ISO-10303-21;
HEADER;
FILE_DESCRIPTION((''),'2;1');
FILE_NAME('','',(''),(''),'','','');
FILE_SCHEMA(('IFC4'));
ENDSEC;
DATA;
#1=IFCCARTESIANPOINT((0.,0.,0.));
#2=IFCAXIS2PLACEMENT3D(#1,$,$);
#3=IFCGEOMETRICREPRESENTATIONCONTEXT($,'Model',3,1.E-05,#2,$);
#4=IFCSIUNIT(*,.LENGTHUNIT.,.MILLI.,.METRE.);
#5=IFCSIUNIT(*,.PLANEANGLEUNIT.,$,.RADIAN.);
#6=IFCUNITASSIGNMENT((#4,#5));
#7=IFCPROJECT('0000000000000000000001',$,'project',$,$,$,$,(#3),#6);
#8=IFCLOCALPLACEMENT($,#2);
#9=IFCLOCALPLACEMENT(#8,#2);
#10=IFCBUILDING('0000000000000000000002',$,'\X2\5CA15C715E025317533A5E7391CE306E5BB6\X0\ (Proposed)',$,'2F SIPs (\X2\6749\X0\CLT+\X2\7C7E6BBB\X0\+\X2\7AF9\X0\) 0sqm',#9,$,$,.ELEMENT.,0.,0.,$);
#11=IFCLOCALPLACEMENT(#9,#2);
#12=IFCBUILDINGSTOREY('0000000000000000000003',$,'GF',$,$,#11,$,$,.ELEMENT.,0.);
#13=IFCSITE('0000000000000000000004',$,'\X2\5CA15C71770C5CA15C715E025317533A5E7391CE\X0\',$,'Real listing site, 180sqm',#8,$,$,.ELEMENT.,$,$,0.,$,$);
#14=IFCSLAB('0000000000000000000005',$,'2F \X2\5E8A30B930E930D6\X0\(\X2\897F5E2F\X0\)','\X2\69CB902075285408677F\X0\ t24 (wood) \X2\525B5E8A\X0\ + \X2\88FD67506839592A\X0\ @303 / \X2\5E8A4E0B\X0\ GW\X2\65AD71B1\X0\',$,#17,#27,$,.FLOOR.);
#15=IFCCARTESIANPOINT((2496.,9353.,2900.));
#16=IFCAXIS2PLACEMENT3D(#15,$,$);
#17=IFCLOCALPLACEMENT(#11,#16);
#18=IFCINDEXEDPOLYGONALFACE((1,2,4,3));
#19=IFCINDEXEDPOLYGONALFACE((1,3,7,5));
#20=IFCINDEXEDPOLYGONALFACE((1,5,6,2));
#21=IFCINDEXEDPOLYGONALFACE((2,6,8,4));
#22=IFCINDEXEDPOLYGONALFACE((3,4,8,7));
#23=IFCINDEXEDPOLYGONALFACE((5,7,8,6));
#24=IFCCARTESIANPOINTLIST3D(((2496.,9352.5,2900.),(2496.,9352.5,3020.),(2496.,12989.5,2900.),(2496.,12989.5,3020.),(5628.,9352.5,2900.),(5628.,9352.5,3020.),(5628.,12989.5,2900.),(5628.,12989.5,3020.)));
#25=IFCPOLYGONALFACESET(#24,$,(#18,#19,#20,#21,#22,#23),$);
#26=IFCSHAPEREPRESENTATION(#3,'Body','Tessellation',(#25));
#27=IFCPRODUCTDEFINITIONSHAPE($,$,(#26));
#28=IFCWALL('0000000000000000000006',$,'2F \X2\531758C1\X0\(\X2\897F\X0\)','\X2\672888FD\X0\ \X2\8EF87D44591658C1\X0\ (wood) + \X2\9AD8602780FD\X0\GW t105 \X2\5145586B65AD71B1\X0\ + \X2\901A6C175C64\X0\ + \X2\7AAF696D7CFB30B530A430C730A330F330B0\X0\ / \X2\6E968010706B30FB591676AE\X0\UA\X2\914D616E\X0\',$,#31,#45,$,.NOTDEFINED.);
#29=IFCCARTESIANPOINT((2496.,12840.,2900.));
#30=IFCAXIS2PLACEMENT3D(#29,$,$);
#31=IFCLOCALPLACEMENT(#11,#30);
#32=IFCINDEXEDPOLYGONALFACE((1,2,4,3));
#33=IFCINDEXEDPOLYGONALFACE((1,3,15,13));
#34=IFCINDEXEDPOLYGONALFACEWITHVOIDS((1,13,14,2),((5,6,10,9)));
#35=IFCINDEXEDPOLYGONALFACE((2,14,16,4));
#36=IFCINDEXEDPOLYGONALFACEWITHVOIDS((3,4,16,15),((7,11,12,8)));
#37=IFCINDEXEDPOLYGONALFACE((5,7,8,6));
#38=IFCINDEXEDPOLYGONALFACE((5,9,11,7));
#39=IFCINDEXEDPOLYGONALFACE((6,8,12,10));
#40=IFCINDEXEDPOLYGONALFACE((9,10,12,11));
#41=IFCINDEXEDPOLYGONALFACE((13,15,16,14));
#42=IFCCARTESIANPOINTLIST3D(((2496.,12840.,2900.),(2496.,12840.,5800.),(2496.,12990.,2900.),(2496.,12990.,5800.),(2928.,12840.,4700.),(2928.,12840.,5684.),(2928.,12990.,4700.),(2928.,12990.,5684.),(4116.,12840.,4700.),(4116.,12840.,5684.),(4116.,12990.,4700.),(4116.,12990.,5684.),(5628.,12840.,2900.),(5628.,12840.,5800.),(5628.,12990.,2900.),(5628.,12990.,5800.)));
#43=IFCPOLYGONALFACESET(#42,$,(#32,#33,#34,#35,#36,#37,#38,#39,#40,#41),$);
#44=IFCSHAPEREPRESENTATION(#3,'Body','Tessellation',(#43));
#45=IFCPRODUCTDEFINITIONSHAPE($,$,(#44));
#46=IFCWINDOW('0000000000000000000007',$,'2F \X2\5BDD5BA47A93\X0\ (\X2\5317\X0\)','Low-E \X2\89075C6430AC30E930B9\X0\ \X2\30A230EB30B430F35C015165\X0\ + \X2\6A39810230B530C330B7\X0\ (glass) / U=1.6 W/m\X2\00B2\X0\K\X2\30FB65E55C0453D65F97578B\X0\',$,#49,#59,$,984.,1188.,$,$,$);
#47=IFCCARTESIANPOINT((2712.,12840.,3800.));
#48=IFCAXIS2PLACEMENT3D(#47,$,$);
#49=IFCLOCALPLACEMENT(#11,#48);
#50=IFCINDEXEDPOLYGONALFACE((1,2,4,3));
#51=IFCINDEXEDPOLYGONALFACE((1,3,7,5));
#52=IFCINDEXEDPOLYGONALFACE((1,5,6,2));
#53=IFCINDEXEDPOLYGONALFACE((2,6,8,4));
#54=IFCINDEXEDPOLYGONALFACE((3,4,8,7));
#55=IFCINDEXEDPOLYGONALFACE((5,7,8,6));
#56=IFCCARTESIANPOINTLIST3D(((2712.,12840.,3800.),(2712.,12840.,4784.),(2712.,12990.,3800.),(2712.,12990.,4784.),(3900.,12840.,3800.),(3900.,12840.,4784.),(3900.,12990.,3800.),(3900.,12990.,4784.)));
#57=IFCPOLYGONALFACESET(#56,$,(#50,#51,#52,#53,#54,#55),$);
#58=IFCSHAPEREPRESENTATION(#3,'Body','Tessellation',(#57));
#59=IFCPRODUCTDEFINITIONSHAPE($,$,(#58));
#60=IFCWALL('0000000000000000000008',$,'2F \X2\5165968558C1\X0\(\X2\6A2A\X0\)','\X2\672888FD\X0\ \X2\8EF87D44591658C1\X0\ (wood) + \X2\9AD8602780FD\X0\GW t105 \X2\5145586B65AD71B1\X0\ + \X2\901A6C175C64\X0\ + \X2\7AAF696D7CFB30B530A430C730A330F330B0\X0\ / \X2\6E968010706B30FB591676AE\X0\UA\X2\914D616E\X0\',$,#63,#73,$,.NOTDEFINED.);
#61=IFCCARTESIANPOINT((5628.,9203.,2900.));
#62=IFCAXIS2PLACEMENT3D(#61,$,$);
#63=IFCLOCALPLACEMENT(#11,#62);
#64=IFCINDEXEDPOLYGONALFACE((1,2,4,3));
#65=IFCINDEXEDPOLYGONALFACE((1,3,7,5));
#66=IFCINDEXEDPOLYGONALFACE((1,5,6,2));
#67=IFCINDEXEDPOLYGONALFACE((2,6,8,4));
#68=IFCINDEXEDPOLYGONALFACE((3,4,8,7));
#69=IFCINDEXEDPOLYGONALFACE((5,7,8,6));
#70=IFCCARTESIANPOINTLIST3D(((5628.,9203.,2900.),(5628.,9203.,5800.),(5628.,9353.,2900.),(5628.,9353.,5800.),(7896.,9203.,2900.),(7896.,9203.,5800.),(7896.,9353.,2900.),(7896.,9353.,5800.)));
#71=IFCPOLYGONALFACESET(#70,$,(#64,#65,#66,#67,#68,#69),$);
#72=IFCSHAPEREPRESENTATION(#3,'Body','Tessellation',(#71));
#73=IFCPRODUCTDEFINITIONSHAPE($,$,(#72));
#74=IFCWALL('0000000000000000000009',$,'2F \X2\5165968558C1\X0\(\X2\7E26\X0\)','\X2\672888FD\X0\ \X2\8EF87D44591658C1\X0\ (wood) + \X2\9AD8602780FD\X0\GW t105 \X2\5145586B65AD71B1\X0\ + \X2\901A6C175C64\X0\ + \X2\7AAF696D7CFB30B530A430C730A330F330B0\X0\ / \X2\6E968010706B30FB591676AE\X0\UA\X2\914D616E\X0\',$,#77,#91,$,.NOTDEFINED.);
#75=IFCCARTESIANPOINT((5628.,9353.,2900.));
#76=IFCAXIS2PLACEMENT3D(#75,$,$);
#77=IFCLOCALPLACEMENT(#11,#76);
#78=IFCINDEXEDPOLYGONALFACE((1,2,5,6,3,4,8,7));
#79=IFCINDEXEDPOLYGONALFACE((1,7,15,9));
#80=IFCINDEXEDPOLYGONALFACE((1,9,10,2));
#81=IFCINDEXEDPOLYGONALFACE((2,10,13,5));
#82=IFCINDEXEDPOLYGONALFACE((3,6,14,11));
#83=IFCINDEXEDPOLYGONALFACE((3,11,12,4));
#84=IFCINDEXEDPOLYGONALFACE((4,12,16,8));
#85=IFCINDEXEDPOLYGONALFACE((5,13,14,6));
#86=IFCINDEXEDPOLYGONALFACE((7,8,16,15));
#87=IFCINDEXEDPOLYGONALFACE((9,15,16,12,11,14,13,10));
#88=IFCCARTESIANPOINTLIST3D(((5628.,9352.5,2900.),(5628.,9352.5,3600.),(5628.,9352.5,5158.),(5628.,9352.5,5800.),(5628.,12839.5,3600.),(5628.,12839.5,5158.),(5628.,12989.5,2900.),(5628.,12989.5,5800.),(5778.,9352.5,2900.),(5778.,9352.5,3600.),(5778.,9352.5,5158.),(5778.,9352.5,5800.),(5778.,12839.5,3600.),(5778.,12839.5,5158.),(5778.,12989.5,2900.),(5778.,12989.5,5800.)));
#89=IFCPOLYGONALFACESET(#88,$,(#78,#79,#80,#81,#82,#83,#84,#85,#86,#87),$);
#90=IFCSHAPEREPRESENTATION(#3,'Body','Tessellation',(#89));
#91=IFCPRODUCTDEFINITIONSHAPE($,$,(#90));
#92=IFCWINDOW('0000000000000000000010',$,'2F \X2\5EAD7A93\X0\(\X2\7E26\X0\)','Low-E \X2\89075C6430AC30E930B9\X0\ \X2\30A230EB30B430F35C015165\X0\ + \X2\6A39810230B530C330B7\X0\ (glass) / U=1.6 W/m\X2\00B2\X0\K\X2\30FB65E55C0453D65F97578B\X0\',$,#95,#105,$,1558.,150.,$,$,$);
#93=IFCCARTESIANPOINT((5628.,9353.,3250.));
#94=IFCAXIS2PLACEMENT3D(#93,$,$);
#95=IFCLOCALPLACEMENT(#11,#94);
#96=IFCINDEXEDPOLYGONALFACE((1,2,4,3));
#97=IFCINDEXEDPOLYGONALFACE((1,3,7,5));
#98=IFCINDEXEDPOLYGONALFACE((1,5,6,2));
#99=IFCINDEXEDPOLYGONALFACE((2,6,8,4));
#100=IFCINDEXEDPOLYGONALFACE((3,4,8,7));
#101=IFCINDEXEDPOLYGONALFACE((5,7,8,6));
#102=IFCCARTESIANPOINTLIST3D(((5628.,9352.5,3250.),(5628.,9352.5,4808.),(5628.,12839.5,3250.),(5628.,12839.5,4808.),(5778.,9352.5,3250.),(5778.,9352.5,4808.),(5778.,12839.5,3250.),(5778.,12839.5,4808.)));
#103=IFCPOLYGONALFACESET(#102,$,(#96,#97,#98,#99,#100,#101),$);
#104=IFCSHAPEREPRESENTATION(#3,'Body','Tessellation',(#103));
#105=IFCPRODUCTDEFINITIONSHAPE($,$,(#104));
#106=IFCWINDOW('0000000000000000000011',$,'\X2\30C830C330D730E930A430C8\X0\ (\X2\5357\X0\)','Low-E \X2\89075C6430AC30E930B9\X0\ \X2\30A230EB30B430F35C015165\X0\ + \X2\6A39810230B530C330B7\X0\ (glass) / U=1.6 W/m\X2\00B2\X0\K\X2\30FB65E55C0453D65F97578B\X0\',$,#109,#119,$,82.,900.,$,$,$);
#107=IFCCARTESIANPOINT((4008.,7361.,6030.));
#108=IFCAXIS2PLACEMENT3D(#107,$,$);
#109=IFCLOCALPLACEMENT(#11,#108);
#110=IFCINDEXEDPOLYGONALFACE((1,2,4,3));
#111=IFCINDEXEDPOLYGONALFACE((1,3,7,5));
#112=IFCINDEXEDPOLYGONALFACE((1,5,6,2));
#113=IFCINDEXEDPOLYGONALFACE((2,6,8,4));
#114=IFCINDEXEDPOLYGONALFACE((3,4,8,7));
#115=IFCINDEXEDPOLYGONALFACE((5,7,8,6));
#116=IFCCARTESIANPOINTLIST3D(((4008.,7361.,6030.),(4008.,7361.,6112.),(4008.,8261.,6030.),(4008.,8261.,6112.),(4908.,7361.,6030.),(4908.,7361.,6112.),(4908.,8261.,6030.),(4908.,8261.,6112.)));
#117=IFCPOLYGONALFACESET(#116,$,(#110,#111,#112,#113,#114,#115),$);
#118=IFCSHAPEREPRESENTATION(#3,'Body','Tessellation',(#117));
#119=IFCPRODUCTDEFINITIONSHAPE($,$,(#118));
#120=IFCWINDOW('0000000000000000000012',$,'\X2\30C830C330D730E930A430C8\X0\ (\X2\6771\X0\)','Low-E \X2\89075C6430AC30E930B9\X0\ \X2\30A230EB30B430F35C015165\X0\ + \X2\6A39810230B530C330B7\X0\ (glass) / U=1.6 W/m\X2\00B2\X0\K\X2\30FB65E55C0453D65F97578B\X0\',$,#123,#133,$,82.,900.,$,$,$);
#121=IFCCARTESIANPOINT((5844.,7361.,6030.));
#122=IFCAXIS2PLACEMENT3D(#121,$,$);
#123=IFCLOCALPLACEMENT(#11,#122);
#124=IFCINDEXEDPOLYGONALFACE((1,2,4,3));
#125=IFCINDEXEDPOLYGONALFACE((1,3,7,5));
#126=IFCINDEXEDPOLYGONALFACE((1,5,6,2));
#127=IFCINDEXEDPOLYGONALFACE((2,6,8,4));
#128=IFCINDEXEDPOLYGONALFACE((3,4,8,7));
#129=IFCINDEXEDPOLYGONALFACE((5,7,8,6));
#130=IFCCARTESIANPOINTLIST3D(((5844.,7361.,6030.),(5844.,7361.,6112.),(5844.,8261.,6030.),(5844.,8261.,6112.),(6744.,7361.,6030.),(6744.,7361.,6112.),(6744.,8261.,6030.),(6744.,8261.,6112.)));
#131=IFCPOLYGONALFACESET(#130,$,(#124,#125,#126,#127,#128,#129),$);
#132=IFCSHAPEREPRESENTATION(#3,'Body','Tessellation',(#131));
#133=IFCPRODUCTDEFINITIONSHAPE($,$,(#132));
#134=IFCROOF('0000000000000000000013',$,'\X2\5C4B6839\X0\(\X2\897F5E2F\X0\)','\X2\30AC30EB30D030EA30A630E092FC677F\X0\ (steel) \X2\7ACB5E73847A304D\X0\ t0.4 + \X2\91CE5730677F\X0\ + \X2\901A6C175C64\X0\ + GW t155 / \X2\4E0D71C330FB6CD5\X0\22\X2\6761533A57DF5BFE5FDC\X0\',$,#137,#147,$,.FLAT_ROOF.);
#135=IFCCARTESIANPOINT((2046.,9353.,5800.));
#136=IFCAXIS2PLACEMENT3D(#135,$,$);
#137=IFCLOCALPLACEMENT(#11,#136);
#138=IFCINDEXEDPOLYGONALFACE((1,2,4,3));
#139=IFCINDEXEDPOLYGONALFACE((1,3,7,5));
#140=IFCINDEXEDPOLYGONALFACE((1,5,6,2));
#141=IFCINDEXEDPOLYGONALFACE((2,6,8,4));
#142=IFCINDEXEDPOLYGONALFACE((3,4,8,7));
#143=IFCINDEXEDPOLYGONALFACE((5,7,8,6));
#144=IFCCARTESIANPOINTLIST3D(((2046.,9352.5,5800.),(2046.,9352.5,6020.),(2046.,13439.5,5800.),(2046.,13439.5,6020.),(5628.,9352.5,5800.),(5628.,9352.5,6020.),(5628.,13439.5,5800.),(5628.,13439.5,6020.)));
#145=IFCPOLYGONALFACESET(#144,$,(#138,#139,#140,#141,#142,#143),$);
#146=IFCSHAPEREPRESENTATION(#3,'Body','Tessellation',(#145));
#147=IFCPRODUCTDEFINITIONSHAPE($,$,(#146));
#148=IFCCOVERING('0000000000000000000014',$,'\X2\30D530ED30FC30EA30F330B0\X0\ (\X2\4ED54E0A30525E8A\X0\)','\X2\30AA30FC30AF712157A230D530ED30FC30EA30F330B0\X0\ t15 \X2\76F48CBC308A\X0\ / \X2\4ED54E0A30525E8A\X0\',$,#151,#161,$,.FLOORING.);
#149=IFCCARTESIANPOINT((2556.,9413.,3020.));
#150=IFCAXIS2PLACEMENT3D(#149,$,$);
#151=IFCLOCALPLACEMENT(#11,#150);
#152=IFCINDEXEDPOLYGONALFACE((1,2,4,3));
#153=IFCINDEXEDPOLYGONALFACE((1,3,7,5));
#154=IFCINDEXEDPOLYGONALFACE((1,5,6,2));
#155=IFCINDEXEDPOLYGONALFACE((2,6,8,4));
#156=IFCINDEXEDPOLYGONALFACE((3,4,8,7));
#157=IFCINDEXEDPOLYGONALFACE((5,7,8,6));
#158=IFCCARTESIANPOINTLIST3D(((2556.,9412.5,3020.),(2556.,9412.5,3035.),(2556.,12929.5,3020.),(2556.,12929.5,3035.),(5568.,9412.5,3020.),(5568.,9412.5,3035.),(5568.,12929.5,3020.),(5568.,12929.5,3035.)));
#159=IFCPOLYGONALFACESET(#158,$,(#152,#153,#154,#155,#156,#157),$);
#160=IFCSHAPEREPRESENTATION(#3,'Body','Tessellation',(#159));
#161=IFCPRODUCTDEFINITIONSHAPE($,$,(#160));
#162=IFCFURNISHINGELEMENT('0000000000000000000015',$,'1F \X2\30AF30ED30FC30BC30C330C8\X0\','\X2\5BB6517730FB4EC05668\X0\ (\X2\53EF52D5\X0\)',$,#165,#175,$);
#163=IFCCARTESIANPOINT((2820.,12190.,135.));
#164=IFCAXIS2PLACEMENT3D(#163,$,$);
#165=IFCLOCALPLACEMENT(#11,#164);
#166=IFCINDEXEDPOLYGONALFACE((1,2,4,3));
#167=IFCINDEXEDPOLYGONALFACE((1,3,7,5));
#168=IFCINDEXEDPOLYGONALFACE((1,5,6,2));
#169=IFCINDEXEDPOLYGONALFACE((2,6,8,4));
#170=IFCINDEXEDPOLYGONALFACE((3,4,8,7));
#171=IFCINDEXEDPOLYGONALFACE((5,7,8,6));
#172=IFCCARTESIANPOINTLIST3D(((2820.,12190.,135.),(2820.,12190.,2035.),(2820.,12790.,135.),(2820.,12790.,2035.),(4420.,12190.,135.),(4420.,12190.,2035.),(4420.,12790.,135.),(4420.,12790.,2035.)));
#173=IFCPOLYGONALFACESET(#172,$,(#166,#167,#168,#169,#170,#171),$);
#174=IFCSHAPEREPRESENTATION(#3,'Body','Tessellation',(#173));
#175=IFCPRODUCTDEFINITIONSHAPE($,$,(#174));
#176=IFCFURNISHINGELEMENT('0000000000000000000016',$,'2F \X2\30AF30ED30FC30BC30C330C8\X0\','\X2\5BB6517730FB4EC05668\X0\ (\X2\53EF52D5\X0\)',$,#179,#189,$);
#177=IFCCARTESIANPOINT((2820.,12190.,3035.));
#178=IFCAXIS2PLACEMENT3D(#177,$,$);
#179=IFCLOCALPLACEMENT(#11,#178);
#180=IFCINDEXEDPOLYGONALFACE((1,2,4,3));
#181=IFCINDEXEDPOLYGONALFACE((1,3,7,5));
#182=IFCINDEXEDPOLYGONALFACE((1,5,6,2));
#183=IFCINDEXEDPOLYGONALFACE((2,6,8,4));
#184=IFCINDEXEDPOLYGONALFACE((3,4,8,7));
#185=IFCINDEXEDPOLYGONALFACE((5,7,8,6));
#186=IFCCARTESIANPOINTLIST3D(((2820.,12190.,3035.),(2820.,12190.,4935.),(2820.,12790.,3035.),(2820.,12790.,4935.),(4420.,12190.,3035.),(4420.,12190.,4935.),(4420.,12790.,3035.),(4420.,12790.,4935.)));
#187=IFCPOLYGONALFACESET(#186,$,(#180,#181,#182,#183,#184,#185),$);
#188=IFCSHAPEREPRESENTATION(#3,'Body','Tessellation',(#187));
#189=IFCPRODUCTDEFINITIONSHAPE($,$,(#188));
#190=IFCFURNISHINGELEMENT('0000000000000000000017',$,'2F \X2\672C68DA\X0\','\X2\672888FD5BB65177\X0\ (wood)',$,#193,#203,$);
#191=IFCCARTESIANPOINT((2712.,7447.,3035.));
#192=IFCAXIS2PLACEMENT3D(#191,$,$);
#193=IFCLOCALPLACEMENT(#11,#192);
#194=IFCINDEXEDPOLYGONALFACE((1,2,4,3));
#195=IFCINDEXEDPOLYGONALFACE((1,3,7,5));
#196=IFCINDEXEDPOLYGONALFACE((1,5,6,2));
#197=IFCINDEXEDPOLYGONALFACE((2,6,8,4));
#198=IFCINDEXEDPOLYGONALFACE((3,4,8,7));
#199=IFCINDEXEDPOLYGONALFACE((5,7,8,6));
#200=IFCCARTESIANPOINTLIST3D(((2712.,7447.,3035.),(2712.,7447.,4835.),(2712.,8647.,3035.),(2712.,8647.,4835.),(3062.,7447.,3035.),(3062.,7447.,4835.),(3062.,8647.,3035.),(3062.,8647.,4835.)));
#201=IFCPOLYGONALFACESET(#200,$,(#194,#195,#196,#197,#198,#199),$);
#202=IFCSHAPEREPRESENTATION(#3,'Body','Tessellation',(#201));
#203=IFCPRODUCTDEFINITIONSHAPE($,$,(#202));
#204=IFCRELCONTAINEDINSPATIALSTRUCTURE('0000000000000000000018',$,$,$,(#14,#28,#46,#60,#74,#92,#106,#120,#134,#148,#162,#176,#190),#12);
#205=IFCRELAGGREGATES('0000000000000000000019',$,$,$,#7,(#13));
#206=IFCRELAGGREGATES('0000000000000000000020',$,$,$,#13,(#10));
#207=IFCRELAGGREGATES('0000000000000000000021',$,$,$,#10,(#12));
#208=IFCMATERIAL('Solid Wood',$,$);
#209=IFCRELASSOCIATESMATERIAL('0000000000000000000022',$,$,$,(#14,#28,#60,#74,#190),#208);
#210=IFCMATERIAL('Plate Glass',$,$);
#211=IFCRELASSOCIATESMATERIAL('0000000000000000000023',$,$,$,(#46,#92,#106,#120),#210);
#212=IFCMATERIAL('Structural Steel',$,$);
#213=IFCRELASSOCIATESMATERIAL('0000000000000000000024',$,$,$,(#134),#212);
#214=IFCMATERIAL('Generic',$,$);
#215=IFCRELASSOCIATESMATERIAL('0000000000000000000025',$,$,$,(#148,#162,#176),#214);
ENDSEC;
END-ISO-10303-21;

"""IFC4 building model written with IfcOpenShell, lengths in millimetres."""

from ifc_helpers import new_model, si_unit, frame, frame_2d, origin, place, context, project, spatial, rectangle, extrude, material, element, fill, save


model = new_model("IFC4")

# Units and contexts
model_context = context("Model", 3, precision=1e-05, world=origin())
ifc_project = project(units=[si_unit("LENGTHUNIT", "METRE", prefix="MILLI"), si_unit("PLANEANGLEUNIT", "RADIAN")], contexts=[model_context])

# Site, building, storey
site_placement = place(None, origin())
site = spatial("IfcSite", under=ifc_project, at=site_placement, Name="岡山県岡山市北区平野", ObjectType="Real listing site, 180sqm", CompositionType="ELEMENT", RefElevation=0.0)
building_placement = place(site_placement, origin())
building = spatial("IfcBuilding", under=site, at=building_placement, Name="岡山市北区平野の家 (Proposed)", ObjectType="2F SIPs (杉CLT+籾殻+竹) 0sqm", CompositionType="ELEMENT", ElevationOfRefHeight=0.0, ElevationOfTerrain=0.0)
storey_placement = place(building_placement, origin())
storey = spatial("IfcBuildingStorey", under=building, at=storey_placement, Name="GF", CompositionType="ELEMENT", Elevation=0.0)

# Slab
ifc_material_1 = material(Name="Solid Wood")
slab_placement = place(storey_placement, frame((2496.0, 9353.0, 2900.0)))
element("IfcSlab", 1, at=slab_placement, inside=storey, material=ifc_material_1, Name="2F 床スラブ(西帯)", Description="構造用合板 t24 (wood) 剛床 + 製材根太 @303 / 床下 GW断熱", PredefinedType="FLOOR", context=model_context, shape_type="SweptSolid", body=[
    extrude(rectangle(XDim=3132.0, YDim=3637.0, at=frame_2d((1566.0, 1818.0))), frame((2496.0, 9353.0, 2900.0)), (0.0, 0.0, 1.0), 120.0),
])

# Wall, opening, window
wall_1_placement = place(storey_placement, frame((2496.0, 12840.0, 2900.0)))
wall_1 = element("IfcWall", 2, at=wall_1_placement, inside=storey, material=ifc_material_1, Name="2F 北壁(西)", Description="木製 軸組外壁 (wood) + 高性能GW t105 充填断熱 + 通気層 + 窯業系サイディング / 準耐火・外皮UA配慮", PredefinedType="NOTDEFINED", context=model_context, shape_type="SweptSolid", body=[
    extrude(rectangle(XDim=3132.0, YDim=150.0, at=frame_2d((1566.0, 75.0))), frame((2496.0, 12840.0, 2900.0)), (0.0, 0.0, 1.0), 2900.0),
])
opening_1_placement = place(storey_placement, frame((2712.0, 12840.0, 3800.0)))
opening_1 = element("IfcOpeningElement", 3, at=opening_1_placement, cuts=wall_1, PredefinedType="NOTDEFINED", context=model_context, shape_type="SweptSolid", body=[
    extrude(rectangle(XDim=1188.0, YDim=150.0, at=frame_2d((594.0, 75.0))), frame((2712.0, 12840.0, 3800.0)), (0.0, 0.0, 1.0), 984.0),
])
ifc_material_2 = material(Name="Plate Glass")
window_1_placement = place(storey_placement, frame((2712.0, 12840.0, 3800.0)))
window_1 = element("IfcWindow", 4, at=window_1_placement, inside=storey, material=ifc_material_2, Name="2F 寝室窓 (北)", Description="Low-E 複層ガラス アルゴン封入 + 樹脂サッシ (glass) / U=1.6 W/m²K・日射取得型", OverallHeight=984.0, OverallWidth=1188.0, context=model_context, shape_type="SweptSolid", body=[
    extrude(rectangle(XDim=1188.0, YDim=150.0, at=frame_2d((594.0, 75.0))), frame((2712.0, 12840.0, 3800.0)), (0.0, 0.0, 1.0), 984.0),
])
fill(opening_1, window_1)

# Wall
wall_2_placement = place(storey_placement, frame((5628.0, 9203.0, 2900.0)))
element("IfcWall", 5, at=wall_2_placement, inside=storey, material=ifc_material_1, Name="2F 入隅壁(横)", Description="木製 軸組外壁 (wood) + 高性能GW t105 充填断熱 + 通気層 + 窯業系サイディング / 準耐火・外皮UA配慮", PredefinedType="NOTDEFINED", context=model_context, shape_type="SweptSolid", body=[
    extrude(rectangle(XDim=2268.0, YDim=150.0, at=frame_2d((1134.0, 75.0))), frame((5628.0, 9203.0, 2900.0)), (0.0, 0.0, 1.0), 2900.0),
])

# Wall, opening, window
wall_3_placement = place(storey_placement, frame((5628.0, 9353.0, 2900.0)))
wall_3 = element("IfcWall", 6, at=wall_3_placement, inside=storey, material=ifc_material_1, Name="2F 入隅壁(縦)", Description="木製 軸組外壁 (wood) + 高性能GW t105 充填断熱 + 通気層 + 窯業系サイディング / 準耐火・外皮UA配慮", PredefinedType="NOTDEFINED", context=model_context, shape_type="SweptSolid", body=[
    extrude(rectangle(XDim=150.0, YDim=3637.0, at=frame_2d((75.0, 1818.0))), frame((5628.0, 9353.0, 2900.0)), (0.0, 0.0, 1.0), 2900.0),
])
opening_2_placement = place(storey_placement, frame((5628.0, 9353.0, 3250.0)))
opening_2 = element("IfcOpeningElement", 7, at=opening_2_placement, cuts=wall_3, PredefinedType="NOTDEFINED", context=model_context, shape_type="SweptSolid", body=[
    extrude(rectangle(XDim=150.0, YDim=3487.0, at=frame_2d((75.0, 1743.0))), frame((5628.0, 9353.0, 3250.0)), (0.0, 0.0, 1.0), 1558.0),
])
window_2_placement = place(storey_placement, frame((5628.0, 9353.0, 3250.0)))
window_2 = element("IfcWindow", 8, at=window_2_placement, inside=storey, material=ifc_material_2, Name="2F 庭窓(縦)", Description="Low-E 複層ガラス アルゴン封入 + 樹脂サッシ (glass) / U=1.6 W/m²K・日射取得型", OverallHeight=1558.0, OverallWidth=150.0, context=model_context, shape_type="SweptSolid", body=[
    extrude(rectangle(XDim=150.0, YDim=3487.0, at=frame_2d((75.0, 1743.0))), frame((5628.0, 9353.0, 3250.0)), (0.0, 0.0, 1.0), 1558.0),
])
fill(opening_2, window_2)

# Windows
window_3_placement = place(storey_placement, frame((4008.0, 7361.0, 6030.0)))
element("IfcWindow", 9, at=window_3_placement, inside=storey, material=ifc_material_2, Name="トップライト (南)", Description="Low-E 複層ガラス アルゴン封入 + 樹脂サッシ (glass) / U=1.6 W/m²K・日射取得型", OverallHeight=82.0, OverallWidth=900.0, context=model_context, shape_type="SweptSolid", body=[
    extrude(rectangle(XDim=900.0, YDim=900.0, at=frame_2d((450.0, 450.0))), frame((4008.0, 7361.0, 6030.0)), (0.0, 0.0, 1.0), 82.0),
])
window_4_placement = place(storey_placement, frame((5844.0, 7361.0, 6030.0)))
element("IfcWindow", 10, at=window_4_placement, inside=storey, material=ifc_material_2, Name="トップライト (東)", Description="Low-E 複層ガラス アルゴン封入 + 樹脂サッシ (glass) / U=1.6 W/m²K・日射取得型", OverallHeight=82.0, OverallWidth=900.0, context=model_context, shape_type="SweptSolid", body=[
    extrude(rectangle(XDim=900.0, YDim=900.0, at=frame_2d((450.0, 450.0))), frame((5844.0, 7361.0, 6030.0)), (0.0, 0.0, 1.0), 82.0),
])

# Roof
ifc_material_3 = material(Name="Structural Steel")
for number, where, name in (
    (11, (2046.0, 9353.0, 5800.0), "屋根(西帯)"),
):
    element("IfcRoof", number, at=place(storey_placement, frame(where)), inside=storey, material=ifc_material_3, Name=name, Description="ガルバリウム鋼板 (steel) 立平葺き t0.4 + 野地板 + 通気層 + GW t155 / 不燃・法22条区域対応", PredefinedType="FLAT_ROOF", context=model_context, shape_type="SweptSolid", body=[
        extrude(rectangle(XDim=3582.0, YDim=4087.0, at=frame_2d((1791.0, 2043.0))), frame((2046.0, 9353.0, 5800.0)), (0.0, 0.0, 1.0), 220.0),
    ])

# Covering
ifc_material_4 = material(Name="Generic")
covering_placement = place(storey_placement, frame((2556.0, 9413.0, 3020.0)))
element("IfcCovering", 12, at=covering_placement, inside=storey, material=ifc_material_4, Name="フローリング (仕上げ床)", Description="オーク無垢フローリング t15 直貼り / 仕上げ床", PredefinedType="FLOORING", context=model_context, shape_type="SweptSolid", body=[
    extrude(rectangle(XDim=3012.0, YDim=3517.0, at=frame_2d((1506.0, 1758.0))), frame((2556.0, 9413.0, 3020.0)), (0.0, 0.0, 1.0), 15.0),
])

# Furnishing elements
furnishing_1_placement = place(storey_placement, frame((2820.0, 12190.0, 135.0)))
element("IfcFurnishingElement", 13, at=furnishing_1_placement, inside=storey, material=ifc_material_4, Name="1F クローゼット", Description="家具・什器 (可動)", context=model_context, shape_type="SweptSolid", body=[
    extrude(rectangle(XDim=1600.0, YDim=600.0, at=frame_2d((800.0, 300.0))), frame((2820.0, 12190.0, 135.0)), (0.0, 0.0, 1.0), 1900.0),
])
furnishing_2_placement = place(storey_placement, frame((2820.0, 12190.0, 3035.0)))
element("IfcFurnishingElement", 14, at=furnishing_2_placement, inside=storey, material=ifc_material_4, Name="2F クローゼット", Description="家具・什器 (可動)", context=model_context, shape_type="SweptSolid", body=[
    extrude(rectangle(XDim=1600.0, YDim=600.0, at=frame_2d((800.0, 300.0))), frame((2820.0, 12190.0, 3035.0)), (0.0, 0.0, 1.0), 1900.0),
])
furnishing_3_placement = place(storey_placement, frame((2712.0, 7447.0, 3035.0)))
element("IfcFurnishingElement", 15, at=furnishing_3_placement, inside=storey, material=ifc_material_1, Name="2F 本棚", Description="木製家具 (wood)", context=model_context, shape_type="SweptSolid", body=[
    extrude(rectangle(XDim=350.0, YDim=1200.0, at=frame_2d((175.0, 600.0))), frame((2712.0, 7447.0, 3035.0)), (0.0, 0.0, 1.0), 1800.0),
])

save(model, "model.ifc")
